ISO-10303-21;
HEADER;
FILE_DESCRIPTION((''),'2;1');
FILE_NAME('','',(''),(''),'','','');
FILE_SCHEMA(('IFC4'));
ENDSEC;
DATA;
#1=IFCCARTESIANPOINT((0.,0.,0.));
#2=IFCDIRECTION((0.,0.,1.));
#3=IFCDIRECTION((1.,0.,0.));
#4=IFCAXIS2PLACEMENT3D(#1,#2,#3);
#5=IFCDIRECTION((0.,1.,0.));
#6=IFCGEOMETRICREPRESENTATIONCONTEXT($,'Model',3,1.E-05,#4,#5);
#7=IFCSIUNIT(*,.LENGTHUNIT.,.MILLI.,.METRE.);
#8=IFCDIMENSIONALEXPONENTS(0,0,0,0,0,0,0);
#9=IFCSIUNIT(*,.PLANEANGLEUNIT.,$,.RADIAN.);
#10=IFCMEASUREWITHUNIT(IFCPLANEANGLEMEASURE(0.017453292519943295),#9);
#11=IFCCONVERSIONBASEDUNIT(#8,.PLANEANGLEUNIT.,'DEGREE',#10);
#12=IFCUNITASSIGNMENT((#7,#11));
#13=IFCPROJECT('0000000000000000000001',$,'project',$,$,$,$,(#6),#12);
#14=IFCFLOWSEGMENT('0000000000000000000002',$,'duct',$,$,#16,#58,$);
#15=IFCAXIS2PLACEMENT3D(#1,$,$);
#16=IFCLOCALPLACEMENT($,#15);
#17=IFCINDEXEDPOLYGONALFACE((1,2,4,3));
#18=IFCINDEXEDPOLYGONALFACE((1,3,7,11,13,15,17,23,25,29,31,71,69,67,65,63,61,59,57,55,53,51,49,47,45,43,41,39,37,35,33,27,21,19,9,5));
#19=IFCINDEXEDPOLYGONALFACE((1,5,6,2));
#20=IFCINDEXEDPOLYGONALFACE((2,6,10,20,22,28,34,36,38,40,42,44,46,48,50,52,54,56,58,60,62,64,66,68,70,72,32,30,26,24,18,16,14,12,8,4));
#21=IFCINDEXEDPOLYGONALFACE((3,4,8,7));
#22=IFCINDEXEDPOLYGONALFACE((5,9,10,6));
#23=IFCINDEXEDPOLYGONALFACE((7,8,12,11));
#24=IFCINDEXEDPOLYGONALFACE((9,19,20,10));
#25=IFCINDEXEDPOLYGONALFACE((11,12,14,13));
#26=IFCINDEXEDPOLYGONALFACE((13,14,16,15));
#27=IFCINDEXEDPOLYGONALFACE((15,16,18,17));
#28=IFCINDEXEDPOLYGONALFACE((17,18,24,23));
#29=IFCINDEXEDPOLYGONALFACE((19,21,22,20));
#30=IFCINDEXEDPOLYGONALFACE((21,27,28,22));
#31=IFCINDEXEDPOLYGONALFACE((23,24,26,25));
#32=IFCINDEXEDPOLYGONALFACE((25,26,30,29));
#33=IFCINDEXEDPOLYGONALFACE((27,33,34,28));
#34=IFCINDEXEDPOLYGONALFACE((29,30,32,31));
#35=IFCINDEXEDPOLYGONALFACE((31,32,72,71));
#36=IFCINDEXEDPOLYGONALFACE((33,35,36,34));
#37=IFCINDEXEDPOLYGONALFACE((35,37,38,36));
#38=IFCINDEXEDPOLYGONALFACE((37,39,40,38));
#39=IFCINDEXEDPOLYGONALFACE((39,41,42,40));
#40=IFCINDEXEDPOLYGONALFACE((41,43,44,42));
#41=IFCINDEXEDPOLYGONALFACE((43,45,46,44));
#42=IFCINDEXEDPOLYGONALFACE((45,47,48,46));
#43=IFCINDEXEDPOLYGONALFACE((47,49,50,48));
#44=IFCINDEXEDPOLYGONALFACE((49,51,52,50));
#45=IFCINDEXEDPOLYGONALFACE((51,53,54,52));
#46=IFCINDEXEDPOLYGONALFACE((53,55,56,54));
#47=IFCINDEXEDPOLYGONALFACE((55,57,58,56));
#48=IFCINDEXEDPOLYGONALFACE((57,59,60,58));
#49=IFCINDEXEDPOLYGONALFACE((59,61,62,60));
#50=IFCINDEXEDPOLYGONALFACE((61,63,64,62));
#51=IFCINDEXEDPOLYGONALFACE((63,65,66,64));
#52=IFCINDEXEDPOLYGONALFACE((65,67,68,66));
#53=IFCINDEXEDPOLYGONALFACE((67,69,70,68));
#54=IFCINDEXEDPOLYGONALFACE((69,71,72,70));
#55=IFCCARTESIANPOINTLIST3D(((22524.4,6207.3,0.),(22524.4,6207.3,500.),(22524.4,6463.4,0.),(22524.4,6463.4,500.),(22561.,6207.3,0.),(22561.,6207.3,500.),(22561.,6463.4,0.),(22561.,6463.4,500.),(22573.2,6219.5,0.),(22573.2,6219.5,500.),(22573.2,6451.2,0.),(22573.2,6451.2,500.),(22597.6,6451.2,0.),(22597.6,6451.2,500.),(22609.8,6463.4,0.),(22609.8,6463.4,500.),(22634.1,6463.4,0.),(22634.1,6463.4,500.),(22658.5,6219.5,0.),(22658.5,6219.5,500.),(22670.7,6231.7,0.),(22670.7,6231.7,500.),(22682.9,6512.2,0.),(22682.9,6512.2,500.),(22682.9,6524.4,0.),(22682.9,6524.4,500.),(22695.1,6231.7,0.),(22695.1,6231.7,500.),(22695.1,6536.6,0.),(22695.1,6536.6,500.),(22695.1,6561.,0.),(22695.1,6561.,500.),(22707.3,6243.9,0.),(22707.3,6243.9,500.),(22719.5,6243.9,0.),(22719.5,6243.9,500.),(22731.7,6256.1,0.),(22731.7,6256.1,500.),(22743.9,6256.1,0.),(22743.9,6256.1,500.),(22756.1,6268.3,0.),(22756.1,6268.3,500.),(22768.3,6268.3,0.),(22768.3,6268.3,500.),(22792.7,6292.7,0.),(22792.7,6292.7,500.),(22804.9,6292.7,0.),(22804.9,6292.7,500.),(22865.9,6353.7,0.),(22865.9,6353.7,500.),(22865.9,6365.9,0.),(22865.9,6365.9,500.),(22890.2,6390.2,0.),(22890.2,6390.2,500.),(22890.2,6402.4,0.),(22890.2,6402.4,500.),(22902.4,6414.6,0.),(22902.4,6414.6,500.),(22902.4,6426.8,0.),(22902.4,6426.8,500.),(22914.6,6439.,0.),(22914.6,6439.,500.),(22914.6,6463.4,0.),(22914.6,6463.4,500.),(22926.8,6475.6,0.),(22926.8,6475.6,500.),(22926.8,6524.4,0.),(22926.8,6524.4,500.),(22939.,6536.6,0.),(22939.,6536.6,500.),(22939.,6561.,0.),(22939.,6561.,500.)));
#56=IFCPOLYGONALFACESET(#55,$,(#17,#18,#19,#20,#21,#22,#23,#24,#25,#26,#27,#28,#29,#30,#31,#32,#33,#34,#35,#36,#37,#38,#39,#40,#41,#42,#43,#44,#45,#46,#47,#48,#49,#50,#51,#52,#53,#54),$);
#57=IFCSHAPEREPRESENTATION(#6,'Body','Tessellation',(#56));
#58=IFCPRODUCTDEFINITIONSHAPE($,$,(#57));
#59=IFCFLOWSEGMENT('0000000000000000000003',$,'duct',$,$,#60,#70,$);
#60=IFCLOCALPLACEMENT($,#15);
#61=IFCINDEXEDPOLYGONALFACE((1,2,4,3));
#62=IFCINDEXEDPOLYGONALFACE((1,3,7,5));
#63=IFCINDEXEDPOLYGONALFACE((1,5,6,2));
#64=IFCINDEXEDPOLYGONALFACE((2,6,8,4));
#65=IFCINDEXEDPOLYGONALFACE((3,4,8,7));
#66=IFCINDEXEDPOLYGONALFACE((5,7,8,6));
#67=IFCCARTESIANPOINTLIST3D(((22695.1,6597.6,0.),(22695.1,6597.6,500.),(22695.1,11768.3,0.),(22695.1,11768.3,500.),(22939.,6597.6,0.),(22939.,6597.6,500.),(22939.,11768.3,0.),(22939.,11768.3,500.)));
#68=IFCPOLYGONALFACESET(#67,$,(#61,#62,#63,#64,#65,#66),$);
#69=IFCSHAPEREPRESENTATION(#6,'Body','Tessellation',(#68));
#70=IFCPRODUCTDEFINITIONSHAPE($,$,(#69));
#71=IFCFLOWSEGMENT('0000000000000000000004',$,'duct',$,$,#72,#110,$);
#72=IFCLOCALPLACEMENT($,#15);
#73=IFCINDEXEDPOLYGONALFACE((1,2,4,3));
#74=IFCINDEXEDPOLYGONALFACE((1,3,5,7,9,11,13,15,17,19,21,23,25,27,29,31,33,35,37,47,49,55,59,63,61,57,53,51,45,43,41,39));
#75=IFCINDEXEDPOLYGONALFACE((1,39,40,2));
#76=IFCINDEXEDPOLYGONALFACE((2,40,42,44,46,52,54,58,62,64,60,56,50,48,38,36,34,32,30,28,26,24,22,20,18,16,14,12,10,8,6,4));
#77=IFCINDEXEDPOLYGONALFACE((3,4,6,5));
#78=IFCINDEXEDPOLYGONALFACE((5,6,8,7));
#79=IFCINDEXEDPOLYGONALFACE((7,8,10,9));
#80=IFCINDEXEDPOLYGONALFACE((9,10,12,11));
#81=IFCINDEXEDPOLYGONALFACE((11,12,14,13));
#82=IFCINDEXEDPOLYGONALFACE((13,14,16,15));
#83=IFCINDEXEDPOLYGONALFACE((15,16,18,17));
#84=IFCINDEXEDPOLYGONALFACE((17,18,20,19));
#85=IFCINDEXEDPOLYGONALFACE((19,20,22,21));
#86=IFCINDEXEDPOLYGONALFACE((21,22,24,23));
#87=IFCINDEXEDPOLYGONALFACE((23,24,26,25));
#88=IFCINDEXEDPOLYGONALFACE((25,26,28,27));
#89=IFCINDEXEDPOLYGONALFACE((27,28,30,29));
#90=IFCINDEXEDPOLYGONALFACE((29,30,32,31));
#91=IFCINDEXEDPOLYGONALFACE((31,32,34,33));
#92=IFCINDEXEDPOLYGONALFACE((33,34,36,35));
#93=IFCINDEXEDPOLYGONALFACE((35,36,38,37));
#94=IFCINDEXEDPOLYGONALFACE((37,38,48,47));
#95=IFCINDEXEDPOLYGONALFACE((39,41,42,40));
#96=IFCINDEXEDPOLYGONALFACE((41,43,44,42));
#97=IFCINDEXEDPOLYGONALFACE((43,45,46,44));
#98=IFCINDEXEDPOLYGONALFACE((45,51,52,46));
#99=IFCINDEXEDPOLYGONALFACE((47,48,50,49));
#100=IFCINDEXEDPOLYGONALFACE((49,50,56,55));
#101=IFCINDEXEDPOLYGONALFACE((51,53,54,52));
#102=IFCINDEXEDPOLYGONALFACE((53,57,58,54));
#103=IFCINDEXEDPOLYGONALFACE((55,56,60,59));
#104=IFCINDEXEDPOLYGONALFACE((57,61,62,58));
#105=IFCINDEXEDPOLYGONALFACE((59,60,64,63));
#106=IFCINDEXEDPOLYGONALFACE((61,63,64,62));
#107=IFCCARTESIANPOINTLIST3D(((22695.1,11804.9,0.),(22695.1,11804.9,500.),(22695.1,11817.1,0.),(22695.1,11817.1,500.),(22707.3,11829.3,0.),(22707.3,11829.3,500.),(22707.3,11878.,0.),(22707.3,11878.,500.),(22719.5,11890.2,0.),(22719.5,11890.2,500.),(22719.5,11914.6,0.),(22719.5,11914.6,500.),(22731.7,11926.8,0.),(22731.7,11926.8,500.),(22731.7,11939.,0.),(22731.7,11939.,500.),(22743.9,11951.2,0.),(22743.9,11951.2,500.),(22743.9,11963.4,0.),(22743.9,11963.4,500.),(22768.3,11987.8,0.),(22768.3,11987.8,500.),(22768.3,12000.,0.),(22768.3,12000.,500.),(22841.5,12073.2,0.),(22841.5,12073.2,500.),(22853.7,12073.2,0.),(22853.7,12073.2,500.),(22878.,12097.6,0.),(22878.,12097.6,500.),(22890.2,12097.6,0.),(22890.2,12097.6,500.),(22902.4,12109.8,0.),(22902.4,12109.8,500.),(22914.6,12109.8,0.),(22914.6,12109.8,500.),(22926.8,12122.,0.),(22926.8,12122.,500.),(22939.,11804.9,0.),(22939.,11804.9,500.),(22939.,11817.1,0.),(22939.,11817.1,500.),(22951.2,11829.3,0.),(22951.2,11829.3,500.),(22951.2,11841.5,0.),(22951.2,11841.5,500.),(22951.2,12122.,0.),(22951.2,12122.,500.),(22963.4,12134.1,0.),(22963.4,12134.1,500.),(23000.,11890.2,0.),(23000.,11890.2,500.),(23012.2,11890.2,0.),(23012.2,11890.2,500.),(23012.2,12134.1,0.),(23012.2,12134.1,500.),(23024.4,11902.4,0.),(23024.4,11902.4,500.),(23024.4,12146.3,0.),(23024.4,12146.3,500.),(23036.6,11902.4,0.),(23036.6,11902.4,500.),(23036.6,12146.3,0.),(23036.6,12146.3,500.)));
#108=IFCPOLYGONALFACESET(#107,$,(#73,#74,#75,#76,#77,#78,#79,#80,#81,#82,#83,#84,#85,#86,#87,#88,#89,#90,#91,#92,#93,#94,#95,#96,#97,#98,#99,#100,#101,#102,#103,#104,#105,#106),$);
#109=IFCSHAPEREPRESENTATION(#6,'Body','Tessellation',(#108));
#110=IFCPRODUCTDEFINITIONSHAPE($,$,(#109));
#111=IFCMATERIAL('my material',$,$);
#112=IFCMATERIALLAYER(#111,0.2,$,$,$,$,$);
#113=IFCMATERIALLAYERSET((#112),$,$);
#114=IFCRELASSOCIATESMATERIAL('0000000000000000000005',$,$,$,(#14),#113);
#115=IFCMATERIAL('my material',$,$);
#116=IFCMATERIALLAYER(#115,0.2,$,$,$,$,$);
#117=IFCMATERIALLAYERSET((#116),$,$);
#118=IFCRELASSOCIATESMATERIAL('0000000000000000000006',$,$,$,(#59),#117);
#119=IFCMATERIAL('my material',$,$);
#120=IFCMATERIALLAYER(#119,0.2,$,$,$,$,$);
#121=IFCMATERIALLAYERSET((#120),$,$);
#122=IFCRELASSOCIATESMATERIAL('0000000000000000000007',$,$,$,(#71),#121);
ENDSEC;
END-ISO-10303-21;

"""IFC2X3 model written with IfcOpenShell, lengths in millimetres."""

from ifc_helpers import new_model, entity, si_unit, converted_unit, direction, origin_with_axes, place, context, project, polyline, outline, extrude, material, layer, layer_set, layer_usage, element, save


model = new_model("IFC2X3")

# Units and contexts
model_context = context("Model", 3, precision=1e-05, world=origin_with_axes(), true_north=direction((0.0, 1.0, 0.0)))
ifc_project = project(units=[si_unit("LENGTHUNIT", "METRE", prefix="MILLI"), converted_unit("PLANEANGLEUNIT", "DEGREE", entity("IfcPlaneAngleMeasure", 0.017453292519943295), si_unit("PLANEANGLEUNIT", "RADIAN"), dimensions=[0, 0, 0, 0, 0, 0, 0])], contexts=[model_context])

# Flow segments
ifc_material_1 = material(Name="my material")
ifc_layer_1 = layer(ifc_material_1, 0.2)
ifc_layer_set_1 = layer_set([ifc_layer_1])
ifc_layer_usage_1 = layer_usage(ifc_layer_set_1, "AXIS2", "POSITIVE", -0.1)
flow_segment_1_placement = place(None, origin_with_axes())
element("IfcFlowSegment", 1, at=flow_segment_1_placement, material=ifc_layer_usage_1, Name="duct", context=model_context, shape_type="SweptSolid", body=[
    extrude(outline(polyline([(22524.4, 6207.3), (22561.0, 6207.3), (22573.2, 6219.5), (22658.5, 6219.5), (22670.7, 6231.7), (22695.1, 6231.7), (22707.3, 6243.9), (22719.5, 6243.9), (22731.7, 6256.1), (22743.9, 6256.1), (22756.1, 6268.3), (22768.3, 6268.3), (22792.7, 6292.7), (22804.9, 6292.7), (22865.9, 6353.7), (22865.9, 6365.9), (22890.2, 6390.2), (22890.2, 6402.4), (22902.4, 6414.6), (22902.4, 6426.8), (22914.6, 6439.0), (22914.6, 6463.4), (22926.8, 6475.6), (22926.8, 6524.4), (22939.0, 6536.6), (22939.0, 6561.0), (22695.1, 6561.0), (22695.1, 6536.6), (22682.9, 6524.4), (22682.9, 6512.2), (22634.1, 6463.4), (22609.8, 6463.4), (22597.6, 6451.2), (22573.2, 6451.2), (22561.0, 6463.4), (22524.4, 6463.4), (22524.4, 6207.3)])), origin_with_axes(), (0.0, 0.0, 1.0), 500.0),
])
ifc_material_2 = material(Name="my material")
ifc_layer_2 = layer(ifc_material_2, 0.2)
ifc_layer_set_2 = layer_set([ifc_layer_2])
ifc_layer_usage_2 = layer_usage(ifc_layer_set_2, "AXIS2", "POSITIVE", -0.1)
flow_segment_2_placement = place(None, origin_with_axes())
element("IfcFlowSegment", 2, at=flow_segment_2_placement, material=ifc_layer_usage_2, Name="duct", context=model_context, shape_type="SweptSolid", body=[
    extrude(outline(polyline([(22695.1, 6597.6), (22939.0, 6597.6), (22939.0, 11768.3), (22695.1, 11768.3), (22695.1, 6597.6)])), origin_with_axes(), (0.0, 0.0, 1.0), 500.0),
])
ifc_material_3 = material(Name="my material")
ifc_layer_3 = layer(ifc_material_3, 0.2)
ifc_layer_set_3 = layer_set([ifc_layer_3])
ifc_layer_usage_3 = layer_usage(ifc_layer_set_3, "AXIS2", "POSITIVE", -0.1)
flow_segment_3_placement = place(None, origin_with_axes())
element("IfcFlowSegment", 3, at=flow_segment_3_placement, material=ifc_layer_usage_3, Name="duct", context=model_context, shape_type="SweptSolid", body=[
    extrude(outline(polyline([(22695.1, 11804.9), (22939.0, 11804.9), (22939.0, 11817.1), (22951.2, 11829.3), (22951.2, 11841.5), (23000.0, 11890.2), (23012.2, 11890.2), (23024.4, 11902.4), (23036.6, 11902.4), (23036.6, 12146.3), (23024.4, 12146.3), (23012.2, 12134.1), (22963.4, 12134.1), (22951.2, 12122.0), (22926.8, 12122.0), (22914.6, 12109.8), (22902.4, 12109.8), (22890.2, 12097.6), (22878.0, 12097.6), (22853.7, 12073.2), (22841.5, 12073.2), (22768.3, 12000.0), (22768.3, 11987.8), (22743.9, 11963.4), (22743.9, 11951.2), (22731.7, 11939.0), (22731.7, 11926.8), (22719.5, 11914.6), (22719.5, 11890.2), (22707.3, 11878.0), (22707.3, 11829.3), (22695.1, 11817.1), (22695.1, 11804.9)])), origin_with_axes(), (0.0, 0.0, 1.0), 500.0),
])

save(model, "model.ifc")
